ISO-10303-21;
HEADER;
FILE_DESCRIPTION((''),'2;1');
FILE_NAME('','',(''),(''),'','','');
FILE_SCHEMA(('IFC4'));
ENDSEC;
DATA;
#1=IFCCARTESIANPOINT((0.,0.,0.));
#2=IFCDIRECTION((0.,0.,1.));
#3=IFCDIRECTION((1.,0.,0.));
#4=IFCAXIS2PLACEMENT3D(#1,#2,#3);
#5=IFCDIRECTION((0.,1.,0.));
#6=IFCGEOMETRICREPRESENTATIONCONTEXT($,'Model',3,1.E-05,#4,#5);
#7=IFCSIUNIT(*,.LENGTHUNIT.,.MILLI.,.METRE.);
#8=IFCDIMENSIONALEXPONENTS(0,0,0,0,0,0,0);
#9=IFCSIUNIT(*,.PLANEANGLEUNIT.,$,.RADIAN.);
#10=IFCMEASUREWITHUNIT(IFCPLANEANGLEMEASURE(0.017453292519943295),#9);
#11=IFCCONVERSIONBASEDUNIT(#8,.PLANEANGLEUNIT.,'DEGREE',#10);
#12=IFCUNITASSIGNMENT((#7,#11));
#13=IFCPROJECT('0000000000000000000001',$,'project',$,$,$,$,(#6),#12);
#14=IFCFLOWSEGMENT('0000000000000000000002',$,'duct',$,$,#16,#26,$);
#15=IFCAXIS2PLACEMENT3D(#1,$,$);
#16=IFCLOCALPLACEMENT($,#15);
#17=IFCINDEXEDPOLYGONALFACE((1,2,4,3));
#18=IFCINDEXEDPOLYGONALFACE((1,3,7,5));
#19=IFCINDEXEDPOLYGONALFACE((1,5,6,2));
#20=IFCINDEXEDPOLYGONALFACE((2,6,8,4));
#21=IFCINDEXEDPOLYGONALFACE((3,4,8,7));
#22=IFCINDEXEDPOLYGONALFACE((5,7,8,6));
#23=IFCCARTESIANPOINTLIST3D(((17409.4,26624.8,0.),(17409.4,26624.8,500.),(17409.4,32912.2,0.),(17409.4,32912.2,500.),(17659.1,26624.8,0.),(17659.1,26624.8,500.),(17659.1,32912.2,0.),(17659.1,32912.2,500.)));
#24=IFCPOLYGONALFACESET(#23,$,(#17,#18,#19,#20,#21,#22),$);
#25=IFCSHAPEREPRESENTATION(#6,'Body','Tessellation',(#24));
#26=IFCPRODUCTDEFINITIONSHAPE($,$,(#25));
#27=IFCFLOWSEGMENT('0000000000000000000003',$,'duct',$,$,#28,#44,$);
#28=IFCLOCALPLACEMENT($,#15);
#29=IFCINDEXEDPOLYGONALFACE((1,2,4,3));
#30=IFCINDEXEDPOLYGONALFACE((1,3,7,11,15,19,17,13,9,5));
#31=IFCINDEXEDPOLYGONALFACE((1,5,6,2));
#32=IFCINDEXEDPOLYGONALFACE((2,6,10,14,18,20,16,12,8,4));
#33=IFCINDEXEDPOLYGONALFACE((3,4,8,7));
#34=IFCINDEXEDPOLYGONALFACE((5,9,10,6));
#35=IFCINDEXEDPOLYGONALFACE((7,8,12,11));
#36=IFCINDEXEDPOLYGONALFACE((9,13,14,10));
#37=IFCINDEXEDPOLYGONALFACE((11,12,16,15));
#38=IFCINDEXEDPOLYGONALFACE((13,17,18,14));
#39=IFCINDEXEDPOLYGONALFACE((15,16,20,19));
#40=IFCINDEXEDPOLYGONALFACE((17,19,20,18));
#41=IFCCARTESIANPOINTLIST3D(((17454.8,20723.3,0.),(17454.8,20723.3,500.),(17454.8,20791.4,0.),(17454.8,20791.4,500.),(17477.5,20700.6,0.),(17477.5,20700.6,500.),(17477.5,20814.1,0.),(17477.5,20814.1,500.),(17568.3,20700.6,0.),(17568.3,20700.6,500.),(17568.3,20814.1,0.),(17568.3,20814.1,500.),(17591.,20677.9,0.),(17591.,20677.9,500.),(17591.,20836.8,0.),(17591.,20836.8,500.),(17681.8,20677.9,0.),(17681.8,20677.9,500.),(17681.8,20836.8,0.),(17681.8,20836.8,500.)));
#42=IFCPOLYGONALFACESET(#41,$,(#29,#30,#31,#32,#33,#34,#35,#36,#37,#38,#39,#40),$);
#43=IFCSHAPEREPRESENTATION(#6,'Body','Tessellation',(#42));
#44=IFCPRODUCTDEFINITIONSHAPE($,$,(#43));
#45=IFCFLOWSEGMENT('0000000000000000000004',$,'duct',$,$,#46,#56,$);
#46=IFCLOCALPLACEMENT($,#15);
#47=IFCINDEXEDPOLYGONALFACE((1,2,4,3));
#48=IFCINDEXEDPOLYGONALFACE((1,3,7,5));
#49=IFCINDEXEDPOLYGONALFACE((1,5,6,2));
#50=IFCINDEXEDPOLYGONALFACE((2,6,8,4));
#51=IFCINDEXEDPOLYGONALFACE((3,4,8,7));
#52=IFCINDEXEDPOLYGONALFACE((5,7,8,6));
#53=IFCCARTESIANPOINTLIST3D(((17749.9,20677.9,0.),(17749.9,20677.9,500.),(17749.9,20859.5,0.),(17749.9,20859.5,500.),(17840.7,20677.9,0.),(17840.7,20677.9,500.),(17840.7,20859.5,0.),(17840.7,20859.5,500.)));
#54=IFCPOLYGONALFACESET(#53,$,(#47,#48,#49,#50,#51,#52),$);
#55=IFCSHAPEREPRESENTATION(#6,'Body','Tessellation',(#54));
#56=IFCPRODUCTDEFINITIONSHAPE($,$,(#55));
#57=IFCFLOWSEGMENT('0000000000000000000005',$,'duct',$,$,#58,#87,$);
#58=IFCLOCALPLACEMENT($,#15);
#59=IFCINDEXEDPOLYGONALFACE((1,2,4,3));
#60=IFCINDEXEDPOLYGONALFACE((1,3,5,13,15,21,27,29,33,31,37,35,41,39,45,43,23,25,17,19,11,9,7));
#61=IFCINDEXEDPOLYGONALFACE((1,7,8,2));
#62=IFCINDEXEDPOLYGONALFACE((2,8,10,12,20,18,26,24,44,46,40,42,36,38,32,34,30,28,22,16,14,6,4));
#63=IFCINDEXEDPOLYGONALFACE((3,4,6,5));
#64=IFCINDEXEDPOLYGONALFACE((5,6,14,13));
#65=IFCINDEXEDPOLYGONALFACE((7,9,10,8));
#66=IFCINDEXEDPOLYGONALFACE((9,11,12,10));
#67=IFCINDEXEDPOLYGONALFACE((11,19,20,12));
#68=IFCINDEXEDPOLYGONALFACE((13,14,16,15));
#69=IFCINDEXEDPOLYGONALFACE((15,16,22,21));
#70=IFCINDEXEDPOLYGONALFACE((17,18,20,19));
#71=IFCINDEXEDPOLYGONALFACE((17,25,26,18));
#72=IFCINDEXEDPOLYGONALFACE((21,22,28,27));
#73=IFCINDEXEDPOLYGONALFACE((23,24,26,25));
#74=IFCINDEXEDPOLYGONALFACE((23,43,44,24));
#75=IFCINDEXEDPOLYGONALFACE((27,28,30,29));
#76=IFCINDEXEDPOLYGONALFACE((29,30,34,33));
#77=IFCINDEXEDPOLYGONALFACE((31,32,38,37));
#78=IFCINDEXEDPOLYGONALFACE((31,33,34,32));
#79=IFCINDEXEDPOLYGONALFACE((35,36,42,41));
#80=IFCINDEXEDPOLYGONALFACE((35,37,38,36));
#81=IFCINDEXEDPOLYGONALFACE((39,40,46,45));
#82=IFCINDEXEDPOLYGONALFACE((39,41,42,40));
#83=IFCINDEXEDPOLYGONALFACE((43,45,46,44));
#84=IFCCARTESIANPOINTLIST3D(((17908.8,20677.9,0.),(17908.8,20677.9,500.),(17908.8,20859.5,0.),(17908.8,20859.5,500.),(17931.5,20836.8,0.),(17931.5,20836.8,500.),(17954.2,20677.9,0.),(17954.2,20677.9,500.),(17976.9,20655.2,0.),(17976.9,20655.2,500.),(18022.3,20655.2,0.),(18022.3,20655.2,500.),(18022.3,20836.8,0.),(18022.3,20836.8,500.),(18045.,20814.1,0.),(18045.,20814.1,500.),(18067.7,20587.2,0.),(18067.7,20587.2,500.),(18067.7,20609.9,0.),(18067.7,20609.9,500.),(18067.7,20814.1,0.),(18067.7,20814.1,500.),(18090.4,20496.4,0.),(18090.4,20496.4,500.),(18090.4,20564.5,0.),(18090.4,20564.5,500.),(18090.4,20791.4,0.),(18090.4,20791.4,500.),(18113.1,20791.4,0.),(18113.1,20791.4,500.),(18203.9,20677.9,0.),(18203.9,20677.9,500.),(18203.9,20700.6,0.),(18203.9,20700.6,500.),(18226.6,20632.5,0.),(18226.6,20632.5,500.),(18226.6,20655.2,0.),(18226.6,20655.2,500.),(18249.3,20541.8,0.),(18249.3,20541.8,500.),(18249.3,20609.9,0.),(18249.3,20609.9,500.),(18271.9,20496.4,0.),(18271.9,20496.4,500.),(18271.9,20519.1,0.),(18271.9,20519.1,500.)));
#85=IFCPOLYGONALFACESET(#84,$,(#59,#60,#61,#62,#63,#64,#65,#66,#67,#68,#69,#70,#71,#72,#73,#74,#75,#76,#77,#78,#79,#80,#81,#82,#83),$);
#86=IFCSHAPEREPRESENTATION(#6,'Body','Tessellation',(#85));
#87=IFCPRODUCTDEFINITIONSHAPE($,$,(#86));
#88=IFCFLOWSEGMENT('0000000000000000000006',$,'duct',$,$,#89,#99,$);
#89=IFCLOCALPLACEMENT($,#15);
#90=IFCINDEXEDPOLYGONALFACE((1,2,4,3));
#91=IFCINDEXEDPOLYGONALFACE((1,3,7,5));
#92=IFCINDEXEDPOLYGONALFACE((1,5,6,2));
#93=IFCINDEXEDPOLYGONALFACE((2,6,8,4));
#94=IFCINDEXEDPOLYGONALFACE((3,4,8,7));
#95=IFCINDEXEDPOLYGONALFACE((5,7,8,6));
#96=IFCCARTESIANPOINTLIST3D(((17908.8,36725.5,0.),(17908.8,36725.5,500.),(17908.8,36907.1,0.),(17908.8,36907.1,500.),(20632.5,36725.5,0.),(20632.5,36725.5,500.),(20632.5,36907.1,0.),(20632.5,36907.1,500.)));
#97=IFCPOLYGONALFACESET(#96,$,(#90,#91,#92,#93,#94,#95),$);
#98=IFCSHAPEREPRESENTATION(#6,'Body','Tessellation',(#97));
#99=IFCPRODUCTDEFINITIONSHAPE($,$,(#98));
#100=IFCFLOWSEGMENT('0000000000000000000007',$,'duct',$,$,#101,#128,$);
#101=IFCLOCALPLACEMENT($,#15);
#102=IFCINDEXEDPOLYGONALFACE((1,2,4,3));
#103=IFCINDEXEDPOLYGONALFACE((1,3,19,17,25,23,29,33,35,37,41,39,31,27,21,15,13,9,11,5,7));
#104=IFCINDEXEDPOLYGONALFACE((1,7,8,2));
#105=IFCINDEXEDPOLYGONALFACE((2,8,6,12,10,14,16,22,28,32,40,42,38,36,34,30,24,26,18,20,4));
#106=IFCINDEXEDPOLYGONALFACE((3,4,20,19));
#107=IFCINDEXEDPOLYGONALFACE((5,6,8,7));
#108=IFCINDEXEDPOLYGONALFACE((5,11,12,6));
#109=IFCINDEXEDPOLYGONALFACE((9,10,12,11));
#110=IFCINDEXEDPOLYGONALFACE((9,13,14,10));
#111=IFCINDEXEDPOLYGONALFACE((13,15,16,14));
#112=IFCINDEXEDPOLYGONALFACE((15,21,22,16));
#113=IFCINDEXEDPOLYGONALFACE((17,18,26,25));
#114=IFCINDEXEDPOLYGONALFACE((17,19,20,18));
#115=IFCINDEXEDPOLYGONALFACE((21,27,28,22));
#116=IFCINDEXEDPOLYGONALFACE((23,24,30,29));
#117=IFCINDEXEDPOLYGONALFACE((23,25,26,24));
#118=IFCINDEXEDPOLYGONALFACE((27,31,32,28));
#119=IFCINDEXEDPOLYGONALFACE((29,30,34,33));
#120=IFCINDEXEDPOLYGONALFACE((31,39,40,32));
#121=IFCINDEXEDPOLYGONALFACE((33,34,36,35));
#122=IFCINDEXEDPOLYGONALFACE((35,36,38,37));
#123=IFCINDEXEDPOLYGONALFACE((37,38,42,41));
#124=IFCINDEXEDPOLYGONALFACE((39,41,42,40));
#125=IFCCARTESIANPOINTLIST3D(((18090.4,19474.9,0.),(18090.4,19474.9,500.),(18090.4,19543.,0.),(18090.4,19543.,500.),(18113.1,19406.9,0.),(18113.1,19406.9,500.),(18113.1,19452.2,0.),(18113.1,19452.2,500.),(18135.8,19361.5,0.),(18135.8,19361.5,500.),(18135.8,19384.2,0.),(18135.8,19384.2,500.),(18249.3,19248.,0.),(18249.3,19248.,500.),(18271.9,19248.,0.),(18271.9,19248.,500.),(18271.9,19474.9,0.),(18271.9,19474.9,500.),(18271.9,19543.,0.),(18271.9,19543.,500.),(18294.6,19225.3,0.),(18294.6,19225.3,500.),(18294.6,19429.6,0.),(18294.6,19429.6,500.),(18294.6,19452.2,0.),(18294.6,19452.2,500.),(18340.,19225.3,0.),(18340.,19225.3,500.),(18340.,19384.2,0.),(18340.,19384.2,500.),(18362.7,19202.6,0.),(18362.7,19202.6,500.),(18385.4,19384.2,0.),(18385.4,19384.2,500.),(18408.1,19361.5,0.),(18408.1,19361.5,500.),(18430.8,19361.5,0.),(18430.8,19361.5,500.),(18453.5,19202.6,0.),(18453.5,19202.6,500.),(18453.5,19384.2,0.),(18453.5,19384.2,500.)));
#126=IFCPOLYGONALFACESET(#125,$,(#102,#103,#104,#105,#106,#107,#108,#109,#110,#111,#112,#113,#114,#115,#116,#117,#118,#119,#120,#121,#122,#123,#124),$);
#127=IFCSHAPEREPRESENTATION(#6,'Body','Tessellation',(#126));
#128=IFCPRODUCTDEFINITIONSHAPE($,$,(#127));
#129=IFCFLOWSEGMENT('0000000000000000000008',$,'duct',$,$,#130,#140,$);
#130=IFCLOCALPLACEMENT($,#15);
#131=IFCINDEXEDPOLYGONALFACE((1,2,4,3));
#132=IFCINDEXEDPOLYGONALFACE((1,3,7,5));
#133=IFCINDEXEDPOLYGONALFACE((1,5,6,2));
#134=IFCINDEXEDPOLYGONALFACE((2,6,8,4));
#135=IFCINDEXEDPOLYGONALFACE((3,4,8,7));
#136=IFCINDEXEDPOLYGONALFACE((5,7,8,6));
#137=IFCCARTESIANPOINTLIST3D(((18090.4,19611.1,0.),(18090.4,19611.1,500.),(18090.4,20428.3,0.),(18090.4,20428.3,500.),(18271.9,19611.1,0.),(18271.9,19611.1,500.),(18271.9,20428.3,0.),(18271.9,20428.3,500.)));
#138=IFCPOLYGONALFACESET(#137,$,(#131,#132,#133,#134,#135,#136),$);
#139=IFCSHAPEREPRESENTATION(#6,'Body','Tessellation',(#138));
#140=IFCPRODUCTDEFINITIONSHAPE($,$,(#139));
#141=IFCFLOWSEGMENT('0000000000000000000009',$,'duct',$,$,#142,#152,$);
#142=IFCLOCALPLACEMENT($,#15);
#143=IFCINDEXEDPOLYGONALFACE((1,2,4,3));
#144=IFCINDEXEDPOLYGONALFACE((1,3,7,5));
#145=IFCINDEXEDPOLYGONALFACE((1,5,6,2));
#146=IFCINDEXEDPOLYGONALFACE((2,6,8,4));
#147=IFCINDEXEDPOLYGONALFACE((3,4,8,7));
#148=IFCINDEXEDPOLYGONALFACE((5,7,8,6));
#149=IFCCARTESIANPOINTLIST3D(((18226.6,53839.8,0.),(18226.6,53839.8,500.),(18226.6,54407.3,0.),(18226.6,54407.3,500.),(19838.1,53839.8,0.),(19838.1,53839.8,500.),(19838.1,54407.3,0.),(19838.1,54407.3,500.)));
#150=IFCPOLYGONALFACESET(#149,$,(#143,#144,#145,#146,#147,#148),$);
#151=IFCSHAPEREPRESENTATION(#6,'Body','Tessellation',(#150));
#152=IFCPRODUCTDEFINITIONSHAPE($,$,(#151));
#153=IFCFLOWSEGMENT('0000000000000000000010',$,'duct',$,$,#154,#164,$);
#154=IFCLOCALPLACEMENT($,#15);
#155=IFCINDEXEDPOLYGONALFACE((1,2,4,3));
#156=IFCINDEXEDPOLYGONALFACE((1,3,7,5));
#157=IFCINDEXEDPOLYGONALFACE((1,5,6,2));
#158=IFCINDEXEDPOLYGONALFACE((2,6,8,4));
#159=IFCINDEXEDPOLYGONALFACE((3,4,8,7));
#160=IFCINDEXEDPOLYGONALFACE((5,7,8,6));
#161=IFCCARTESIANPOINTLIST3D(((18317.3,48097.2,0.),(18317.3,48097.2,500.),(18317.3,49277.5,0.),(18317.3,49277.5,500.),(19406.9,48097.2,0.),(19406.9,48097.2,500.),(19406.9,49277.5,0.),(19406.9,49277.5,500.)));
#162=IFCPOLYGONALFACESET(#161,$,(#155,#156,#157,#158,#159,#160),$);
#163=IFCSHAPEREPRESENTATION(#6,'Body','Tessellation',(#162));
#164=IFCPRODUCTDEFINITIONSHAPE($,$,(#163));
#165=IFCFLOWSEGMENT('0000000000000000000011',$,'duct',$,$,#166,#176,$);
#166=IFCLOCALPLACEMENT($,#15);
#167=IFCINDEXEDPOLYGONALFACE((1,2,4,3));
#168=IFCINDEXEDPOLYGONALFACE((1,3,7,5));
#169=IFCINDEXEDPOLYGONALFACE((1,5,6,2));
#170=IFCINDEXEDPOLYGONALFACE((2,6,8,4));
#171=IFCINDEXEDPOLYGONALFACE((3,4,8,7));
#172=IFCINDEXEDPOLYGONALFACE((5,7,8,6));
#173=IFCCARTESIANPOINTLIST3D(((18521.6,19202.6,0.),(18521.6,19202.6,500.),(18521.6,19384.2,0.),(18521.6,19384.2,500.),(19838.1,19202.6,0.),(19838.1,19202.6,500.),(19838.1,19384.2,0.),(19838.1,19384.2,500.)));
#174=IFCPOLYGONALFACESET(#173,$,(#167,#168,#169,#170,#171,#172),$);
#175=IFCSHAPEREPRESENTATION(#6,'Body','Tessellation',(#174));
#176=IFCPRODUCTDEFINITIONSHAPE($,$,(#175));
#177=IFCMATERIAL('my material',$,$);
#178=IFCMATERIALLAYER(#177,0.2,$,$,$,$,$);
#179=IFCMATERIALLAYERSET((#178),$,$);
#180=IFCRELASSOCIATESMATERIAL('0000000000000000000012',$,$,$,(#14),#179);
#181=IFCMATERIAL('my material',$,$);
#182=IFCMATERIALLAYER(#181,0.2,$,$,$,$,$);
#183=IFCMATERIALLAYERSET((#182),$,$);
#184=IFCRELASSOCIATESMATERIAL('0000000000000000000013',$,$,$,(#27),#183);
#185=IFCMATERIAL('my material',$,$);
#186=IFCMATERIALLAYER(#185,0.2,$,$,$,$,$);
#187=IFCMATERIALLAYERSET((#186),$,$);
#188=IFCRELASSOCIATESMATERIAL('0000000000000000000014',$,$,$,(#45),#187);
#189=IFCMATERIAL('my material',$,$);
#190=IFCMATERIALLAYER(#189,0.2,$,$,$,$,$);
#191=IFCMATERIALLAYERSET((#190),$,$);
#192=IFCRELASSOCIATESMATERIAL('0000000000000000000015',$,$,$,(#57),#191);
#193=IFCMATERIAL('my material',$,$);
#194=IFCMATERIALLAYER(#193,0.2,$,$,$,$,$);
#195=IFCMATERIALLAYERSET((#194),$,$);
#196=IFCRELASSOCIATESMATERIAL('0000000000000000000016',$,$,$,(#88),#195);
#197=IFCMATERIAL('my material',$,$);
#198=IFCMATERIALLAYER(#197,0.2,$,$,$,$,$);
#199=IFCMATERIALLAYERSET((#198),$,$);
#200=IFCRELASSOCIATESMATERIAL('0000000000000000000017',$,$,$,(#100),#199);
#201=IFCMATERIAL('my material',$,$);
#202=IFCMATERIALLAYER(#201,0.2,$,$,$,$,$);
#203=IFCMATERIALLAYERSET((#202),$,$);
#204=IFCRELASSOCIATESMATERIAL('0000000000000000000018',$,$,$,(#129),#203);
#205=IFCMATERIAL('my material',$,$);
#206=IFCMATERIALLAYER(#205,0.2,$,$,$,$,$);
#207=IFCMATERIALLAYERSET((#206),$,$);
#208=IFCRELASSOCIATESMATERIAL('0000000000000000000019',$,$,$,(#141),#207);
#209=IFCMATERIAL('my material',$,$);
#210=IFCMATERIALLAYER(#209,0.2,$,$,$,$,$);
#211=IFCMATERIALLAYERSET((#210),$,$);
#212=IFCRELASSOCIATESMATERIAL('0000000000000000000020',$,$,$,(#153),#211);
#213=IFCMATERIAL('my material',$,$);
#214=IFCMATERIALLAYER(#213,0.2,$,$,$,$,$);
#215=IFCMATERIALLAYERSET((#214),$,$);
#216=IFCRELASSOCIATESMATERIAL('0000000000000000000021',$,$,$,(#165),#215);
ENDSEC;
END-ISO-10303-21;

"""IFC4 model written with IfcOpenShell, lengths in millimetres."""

from ifc_helpers import new_model, entity, si_unit, converted_unit, direction, origin_with_axes, place, context, project, polyline, outline, extrude, material, layer, layer_set, layer_usage, element, save


model = new_model("IFC4")

# Units and contexts
model_context = context("Model", 3, precision=1e-05, world=origin_with_axes(), true_north=direction((0.0, 1.0, 0.0)))
ifc_project = project(units=[si_unit("LENGTHUNIT", "METRE", prefix="MILLI"), converted_unit("PLANEANGLEUNIT", "DEGREE", entity("IfcPlaneAngleMeasure", 0.017453292519943295), si_unit("PLANEANGLEUNIT", "RADIAN"), dimensions=[0, 0, 0, 0, 0, 0, 0])], contexts=[model_context])

# Flow segments
ifc_material_1 = material(Name="my material")
ifc_layer_1 = layer(ifc_material_1, 0.2)
ifc_layer_set_1 = layer_set([ifc_layer_1])
ifc_layer_usage_1 = layer_usage(ifc_layer_set_1, "AXIS2", "POSITIVE", -0.1)
flow_segment_1_placement = place(None, origin_with_axes())
element("IfcFlowSegment", 1, at=flow_segment_1_placement, material=ifc_layer_usage_1, Name="duct", context=model_context, shape_type="SweptSolid", body=[
    extrude(outline(polyline([(17409.4, 26624.8), (17659.1, 26624.8), (17659.1, 32912.2), (17409.4, 32912.2), (17409.4, 26624.8)])), origin_with_axes(), (0.0, 0.0, 1.0), 500.0),
])
ifc_material_2 = material(Name="my material")
ifc_layer_2 = layer(ifc_material_2, 0.2)
ifc_layer_set_2 = layer_set([ifc_layer_2])
ifc_layer_usage_2 = layer_usage(ifc_layer_set_2, "AXIS2", "POSITIVE", -0.1)
flow_segment_2_placement = place(None, origin_with_axes())
element("IfcFlowSegment", 2, at=flow_segment_2_placement, material=ifc_layer_usage_2, Name="duct", context=model_context, shape_type="SweptSolid", body=[
    extrude(outline(polyline([(17454.8, 20723.3), (17477.5, 20700.6), (17568.3, 20700.6), (17591.0, 20677.9), (17681.8, 20677.9), (17681.8, 20836.8), (17591.0, 20836.8), (17568.3, 20814.1), (17477.5, 20814.1), (17454.8, 20791.4), (17454.8, 20723.3)])), origin_with_axes(), (0.0, 0.0, 1.0), 500.0),
])
ifc_material_3 = material(Name="my material")
ifc_layer_3 = layer(ifc_material_3, 0.2)
ifc_layer_set_3 = layer_set([ifc_layer_3])
ifc_layer_usage_3 = layer_usage(ifc_layer_set_3, "AXIS2", "POSITIVE", -0.1)
flow_segment_3_placement = place(None, origin_with_axes())
element("IfcFlowSegment", 3, at=flow_segment_3_placement, material=ifc_layer_usage_3, Name="duct", context=model_context, shape_type="SweptSolid", body=[
    extrude(outline(polyline([(17749.9, 20677.9), (17840.7, 20677.9), (17840.7, 20859.5), (17749.9, 20859.5), (17749.9, 20677.9)])), origin_with_axes(), (0.0, 0.0, 1.0), 500.0),
])
ifc_material_4 = material(Name="my material")
ifc_layer_4 = layer(ifc_material_4, 0.2)
ifc_layer_set_4 = layer_set([ifc_layer_4])
ifc_layer_usage_4 = layer_usage(ifc_layer_set_4, "AXIS2", "POSITIVE", -0.1)
flow_segment_4_placement = place(None, origin_with_axes())
element("IfcFlowSegment", 4, at=flow_segment_4_placement, material=ifc_layer_usage_4, Name="duct", context=model_context, shape_type="SweptSolid", body=[
    extrude(outline(polyline([(17908.8, 20677.9), (17954.2, 20677.9), (17976.9, 20655.2), (18022.3, 20655.2), (18067.7, 20609.9), (18067.7, 20587.2), (18090.4, 20564.5), (18090.4, 20496.4), (18271.9, 20496.4), (18271.9, 20519.1), (18249.3, 20541.8), (18249.3, 20609.9), (18226.6, 20632.5), (18226.6, 20655.2), (18203.9, 20677.9), (18203.9, 20700.6), (18113.1, 20791.4), (18090.4, 20791.4), (18067.7, 20814.1), (18045.0, 20814.1), (18022.3, 20836.8), (17931.5, 20836.8), (17908.8, 20859.5), (17908.8, 20677.9)])), origin_with_axes(), (0.0, 0.0, 1.0), 500.0),
])
ifc_material_5 = material(Name="my material")
ifc_layer_5 = layer(ifc_material_5, 0.2)
ifc_layer_set_5 = layer_set([ifc_layer_5])
ifc_layer_usage_5 = layer_usage(ifc_layer_set_5, "AXIS2", "POSITIVE", -0.1)
flow_segment_5_placement = place(None, origin_with_axes())
element("IfcFlowSegment", 5, at=flow_segment_5_placement, material=ifc_layer_usage_5, Name="duct", context=model_context, shape_type="SweptSolid", body=[
    extrude(outline(polyline([(17908.8, 36725.5), (20632.5, 36725.5), (20632.5, 36907.1), (17908.8, 36907.1), (17908.8, 36725.5)])), origin_with_axes(), (0.0, 0.0, 1.0), 500.0),
])
ifc_material_6 = material(Name="my material")
ifc_layer_6 = layer(ifc_material_6, 0.2)
ifc_layer_set_6 = layer_set([ifc_layer_6])
ifc_layer_usage_6 = layer_usage(ifc_layer_set_6, "AXIS2", "POSITIVE", -0.1)
flow_segment_6_placement = place(None, origin_with_axes())
element("IfcFlowSegment", 6, at=flow_segment_6_placement, material=ifc_layer_usage_6, Name="duct", context=model_context, shape_type="SweptSolid", body=[
    extrude(outline(polyline([(18090.4, 19474.9), (18113.1, 19452.2), (18113.1, 19406.9), (18135.8, 19384.2), (18135.8, 19361.5), (18249.3, 19248.0), (18271.9, 19248.0), (18294.6, 19225.3), (18340.0, 19225.3), (18362.7, 19202.6), (18453.5, 19202.6), (18453.5, 19384.2), (18430.8, 19361.5), (18408.1, 19361.5), (18385.4, 19384.2), (18340.0, 19384.2), (18294.6, 19429.6), (18294.6, 19452.2), (18271.9, 19474.9), (18271.9, 19543.0), (18090.4, 19543.0), (18090.4, 19474.9)])), origin_with_axes(), (0.0, 0.0, 1.0), 500.0),
])
ifc_material_7 = material(Name="my material")
ifc_layer_7 = layer(ifc_material_7, 0.2)
ifc_layer_set_7 = layer_set([ifc_layer_7])
ifc_layer_usage_7 = layer_usage(ifc_layer_set_7, "AXIS2", "POSITIVE", -0.1)
flow_segment_7_placement = place(None, origin_with_axes())
element("IfcFlowSegment", 7, at=flow_segment_7_placement, material=ifc_layer_usage_7, Name="duct", context=model_context, shape_type="SweptSolid", body=[
    extrude(outline(polyline([(18090.4, 19611.1), (18271.9, 19611.1), (18271.9, 20428.3), (18090.4, 20428.3), (18090.4, 19611.1)])), origin_with_axes(), (0.0, 0.0, 1.0), 500.0),
])
ifc_material_8 = material(Name="my material")
ifc_layer_8 = layer(ifc_material_8, 0.2)
ifc_layer_set_8 = layer_set([ifc_layer_8])
ifc_layer_usage_8 = layer_usage(ifc_layer_set_8, "AXIS2", "POSITIVE", -0.1)
flow_segment_8_placement = place(None, origin_with_axes())
element("IfcFlowSegment", 8, at=flow_segment_8_placement, material=ifc_layer_usage_8, Name="duct", context=model_context, shape_type="SweptSolid", body=[
    extrude(outline(polyline([(18226.6, 53839.8), (19838.1, 53839.8), (19838.1, 54407.3), (18226.6, 54407.3), (18226.6, 53839.8)])), origin_with_axes(), (0.0, 0.0, 1.0), 500.0),
])
ifc_material_9 = material(Name="my material")
ifc_layer_9 = layer(ifc_material_9, 0.2)
ifc_layer_set_9 = layer_set([ifc_layer_9])
ifc_layer_usage_9 = layer_usage(ifc_layer_set_9, "AXIS2", "POSITIVE", -0.1)
flow_segment_9_placement = place(None, origin_with_axes())
element("IfcFlowSegment", 9, at=flow_segment_9_placement, material=ifc_layer_usage_9, Name="duct", context=model_context, shape_type="SweptSolid", body=[
    extrude(outline(polyline([(18317.3, 48097.2), (19406.9, 48097.2), (19406.9, 49277.5), (18317.3, 49277.5), (18317.3, 48097.2)])), origin_with_axes(), (0.0, 0.0, 1.0), 500.0),
])
ifc_material_10 = material(Name="my material")
ifc_layer_10 = layer(ifc_material_10, 0.2)
ifc_layer_set_10 = layer_set([ifc_layer_10])
ifc_layer_usage_10 = layer_usage(ifc_layer_set_10, "AXIS2", "POSITIVE", -0.1)
flow_segment_10_placement = place(None, origin_with_axes())
element("IfcFlowSegment", 10, at=flow_segment_10_placement, material=ifc_layer_usage_10, Name="duct", context=model_context, shape_type="SweptSolid", body=[
    extrude(outline(polyline([(18521.6, 19202.6), (19838.1, 19202.6), (19838.1, 19384.2), (18521.6, 19384.2), (18521.6, 19202.6)])), origin_with_axes(), (0.0, 0.0, 1.0), 500.0),
])

save(model, "model.ifc")
